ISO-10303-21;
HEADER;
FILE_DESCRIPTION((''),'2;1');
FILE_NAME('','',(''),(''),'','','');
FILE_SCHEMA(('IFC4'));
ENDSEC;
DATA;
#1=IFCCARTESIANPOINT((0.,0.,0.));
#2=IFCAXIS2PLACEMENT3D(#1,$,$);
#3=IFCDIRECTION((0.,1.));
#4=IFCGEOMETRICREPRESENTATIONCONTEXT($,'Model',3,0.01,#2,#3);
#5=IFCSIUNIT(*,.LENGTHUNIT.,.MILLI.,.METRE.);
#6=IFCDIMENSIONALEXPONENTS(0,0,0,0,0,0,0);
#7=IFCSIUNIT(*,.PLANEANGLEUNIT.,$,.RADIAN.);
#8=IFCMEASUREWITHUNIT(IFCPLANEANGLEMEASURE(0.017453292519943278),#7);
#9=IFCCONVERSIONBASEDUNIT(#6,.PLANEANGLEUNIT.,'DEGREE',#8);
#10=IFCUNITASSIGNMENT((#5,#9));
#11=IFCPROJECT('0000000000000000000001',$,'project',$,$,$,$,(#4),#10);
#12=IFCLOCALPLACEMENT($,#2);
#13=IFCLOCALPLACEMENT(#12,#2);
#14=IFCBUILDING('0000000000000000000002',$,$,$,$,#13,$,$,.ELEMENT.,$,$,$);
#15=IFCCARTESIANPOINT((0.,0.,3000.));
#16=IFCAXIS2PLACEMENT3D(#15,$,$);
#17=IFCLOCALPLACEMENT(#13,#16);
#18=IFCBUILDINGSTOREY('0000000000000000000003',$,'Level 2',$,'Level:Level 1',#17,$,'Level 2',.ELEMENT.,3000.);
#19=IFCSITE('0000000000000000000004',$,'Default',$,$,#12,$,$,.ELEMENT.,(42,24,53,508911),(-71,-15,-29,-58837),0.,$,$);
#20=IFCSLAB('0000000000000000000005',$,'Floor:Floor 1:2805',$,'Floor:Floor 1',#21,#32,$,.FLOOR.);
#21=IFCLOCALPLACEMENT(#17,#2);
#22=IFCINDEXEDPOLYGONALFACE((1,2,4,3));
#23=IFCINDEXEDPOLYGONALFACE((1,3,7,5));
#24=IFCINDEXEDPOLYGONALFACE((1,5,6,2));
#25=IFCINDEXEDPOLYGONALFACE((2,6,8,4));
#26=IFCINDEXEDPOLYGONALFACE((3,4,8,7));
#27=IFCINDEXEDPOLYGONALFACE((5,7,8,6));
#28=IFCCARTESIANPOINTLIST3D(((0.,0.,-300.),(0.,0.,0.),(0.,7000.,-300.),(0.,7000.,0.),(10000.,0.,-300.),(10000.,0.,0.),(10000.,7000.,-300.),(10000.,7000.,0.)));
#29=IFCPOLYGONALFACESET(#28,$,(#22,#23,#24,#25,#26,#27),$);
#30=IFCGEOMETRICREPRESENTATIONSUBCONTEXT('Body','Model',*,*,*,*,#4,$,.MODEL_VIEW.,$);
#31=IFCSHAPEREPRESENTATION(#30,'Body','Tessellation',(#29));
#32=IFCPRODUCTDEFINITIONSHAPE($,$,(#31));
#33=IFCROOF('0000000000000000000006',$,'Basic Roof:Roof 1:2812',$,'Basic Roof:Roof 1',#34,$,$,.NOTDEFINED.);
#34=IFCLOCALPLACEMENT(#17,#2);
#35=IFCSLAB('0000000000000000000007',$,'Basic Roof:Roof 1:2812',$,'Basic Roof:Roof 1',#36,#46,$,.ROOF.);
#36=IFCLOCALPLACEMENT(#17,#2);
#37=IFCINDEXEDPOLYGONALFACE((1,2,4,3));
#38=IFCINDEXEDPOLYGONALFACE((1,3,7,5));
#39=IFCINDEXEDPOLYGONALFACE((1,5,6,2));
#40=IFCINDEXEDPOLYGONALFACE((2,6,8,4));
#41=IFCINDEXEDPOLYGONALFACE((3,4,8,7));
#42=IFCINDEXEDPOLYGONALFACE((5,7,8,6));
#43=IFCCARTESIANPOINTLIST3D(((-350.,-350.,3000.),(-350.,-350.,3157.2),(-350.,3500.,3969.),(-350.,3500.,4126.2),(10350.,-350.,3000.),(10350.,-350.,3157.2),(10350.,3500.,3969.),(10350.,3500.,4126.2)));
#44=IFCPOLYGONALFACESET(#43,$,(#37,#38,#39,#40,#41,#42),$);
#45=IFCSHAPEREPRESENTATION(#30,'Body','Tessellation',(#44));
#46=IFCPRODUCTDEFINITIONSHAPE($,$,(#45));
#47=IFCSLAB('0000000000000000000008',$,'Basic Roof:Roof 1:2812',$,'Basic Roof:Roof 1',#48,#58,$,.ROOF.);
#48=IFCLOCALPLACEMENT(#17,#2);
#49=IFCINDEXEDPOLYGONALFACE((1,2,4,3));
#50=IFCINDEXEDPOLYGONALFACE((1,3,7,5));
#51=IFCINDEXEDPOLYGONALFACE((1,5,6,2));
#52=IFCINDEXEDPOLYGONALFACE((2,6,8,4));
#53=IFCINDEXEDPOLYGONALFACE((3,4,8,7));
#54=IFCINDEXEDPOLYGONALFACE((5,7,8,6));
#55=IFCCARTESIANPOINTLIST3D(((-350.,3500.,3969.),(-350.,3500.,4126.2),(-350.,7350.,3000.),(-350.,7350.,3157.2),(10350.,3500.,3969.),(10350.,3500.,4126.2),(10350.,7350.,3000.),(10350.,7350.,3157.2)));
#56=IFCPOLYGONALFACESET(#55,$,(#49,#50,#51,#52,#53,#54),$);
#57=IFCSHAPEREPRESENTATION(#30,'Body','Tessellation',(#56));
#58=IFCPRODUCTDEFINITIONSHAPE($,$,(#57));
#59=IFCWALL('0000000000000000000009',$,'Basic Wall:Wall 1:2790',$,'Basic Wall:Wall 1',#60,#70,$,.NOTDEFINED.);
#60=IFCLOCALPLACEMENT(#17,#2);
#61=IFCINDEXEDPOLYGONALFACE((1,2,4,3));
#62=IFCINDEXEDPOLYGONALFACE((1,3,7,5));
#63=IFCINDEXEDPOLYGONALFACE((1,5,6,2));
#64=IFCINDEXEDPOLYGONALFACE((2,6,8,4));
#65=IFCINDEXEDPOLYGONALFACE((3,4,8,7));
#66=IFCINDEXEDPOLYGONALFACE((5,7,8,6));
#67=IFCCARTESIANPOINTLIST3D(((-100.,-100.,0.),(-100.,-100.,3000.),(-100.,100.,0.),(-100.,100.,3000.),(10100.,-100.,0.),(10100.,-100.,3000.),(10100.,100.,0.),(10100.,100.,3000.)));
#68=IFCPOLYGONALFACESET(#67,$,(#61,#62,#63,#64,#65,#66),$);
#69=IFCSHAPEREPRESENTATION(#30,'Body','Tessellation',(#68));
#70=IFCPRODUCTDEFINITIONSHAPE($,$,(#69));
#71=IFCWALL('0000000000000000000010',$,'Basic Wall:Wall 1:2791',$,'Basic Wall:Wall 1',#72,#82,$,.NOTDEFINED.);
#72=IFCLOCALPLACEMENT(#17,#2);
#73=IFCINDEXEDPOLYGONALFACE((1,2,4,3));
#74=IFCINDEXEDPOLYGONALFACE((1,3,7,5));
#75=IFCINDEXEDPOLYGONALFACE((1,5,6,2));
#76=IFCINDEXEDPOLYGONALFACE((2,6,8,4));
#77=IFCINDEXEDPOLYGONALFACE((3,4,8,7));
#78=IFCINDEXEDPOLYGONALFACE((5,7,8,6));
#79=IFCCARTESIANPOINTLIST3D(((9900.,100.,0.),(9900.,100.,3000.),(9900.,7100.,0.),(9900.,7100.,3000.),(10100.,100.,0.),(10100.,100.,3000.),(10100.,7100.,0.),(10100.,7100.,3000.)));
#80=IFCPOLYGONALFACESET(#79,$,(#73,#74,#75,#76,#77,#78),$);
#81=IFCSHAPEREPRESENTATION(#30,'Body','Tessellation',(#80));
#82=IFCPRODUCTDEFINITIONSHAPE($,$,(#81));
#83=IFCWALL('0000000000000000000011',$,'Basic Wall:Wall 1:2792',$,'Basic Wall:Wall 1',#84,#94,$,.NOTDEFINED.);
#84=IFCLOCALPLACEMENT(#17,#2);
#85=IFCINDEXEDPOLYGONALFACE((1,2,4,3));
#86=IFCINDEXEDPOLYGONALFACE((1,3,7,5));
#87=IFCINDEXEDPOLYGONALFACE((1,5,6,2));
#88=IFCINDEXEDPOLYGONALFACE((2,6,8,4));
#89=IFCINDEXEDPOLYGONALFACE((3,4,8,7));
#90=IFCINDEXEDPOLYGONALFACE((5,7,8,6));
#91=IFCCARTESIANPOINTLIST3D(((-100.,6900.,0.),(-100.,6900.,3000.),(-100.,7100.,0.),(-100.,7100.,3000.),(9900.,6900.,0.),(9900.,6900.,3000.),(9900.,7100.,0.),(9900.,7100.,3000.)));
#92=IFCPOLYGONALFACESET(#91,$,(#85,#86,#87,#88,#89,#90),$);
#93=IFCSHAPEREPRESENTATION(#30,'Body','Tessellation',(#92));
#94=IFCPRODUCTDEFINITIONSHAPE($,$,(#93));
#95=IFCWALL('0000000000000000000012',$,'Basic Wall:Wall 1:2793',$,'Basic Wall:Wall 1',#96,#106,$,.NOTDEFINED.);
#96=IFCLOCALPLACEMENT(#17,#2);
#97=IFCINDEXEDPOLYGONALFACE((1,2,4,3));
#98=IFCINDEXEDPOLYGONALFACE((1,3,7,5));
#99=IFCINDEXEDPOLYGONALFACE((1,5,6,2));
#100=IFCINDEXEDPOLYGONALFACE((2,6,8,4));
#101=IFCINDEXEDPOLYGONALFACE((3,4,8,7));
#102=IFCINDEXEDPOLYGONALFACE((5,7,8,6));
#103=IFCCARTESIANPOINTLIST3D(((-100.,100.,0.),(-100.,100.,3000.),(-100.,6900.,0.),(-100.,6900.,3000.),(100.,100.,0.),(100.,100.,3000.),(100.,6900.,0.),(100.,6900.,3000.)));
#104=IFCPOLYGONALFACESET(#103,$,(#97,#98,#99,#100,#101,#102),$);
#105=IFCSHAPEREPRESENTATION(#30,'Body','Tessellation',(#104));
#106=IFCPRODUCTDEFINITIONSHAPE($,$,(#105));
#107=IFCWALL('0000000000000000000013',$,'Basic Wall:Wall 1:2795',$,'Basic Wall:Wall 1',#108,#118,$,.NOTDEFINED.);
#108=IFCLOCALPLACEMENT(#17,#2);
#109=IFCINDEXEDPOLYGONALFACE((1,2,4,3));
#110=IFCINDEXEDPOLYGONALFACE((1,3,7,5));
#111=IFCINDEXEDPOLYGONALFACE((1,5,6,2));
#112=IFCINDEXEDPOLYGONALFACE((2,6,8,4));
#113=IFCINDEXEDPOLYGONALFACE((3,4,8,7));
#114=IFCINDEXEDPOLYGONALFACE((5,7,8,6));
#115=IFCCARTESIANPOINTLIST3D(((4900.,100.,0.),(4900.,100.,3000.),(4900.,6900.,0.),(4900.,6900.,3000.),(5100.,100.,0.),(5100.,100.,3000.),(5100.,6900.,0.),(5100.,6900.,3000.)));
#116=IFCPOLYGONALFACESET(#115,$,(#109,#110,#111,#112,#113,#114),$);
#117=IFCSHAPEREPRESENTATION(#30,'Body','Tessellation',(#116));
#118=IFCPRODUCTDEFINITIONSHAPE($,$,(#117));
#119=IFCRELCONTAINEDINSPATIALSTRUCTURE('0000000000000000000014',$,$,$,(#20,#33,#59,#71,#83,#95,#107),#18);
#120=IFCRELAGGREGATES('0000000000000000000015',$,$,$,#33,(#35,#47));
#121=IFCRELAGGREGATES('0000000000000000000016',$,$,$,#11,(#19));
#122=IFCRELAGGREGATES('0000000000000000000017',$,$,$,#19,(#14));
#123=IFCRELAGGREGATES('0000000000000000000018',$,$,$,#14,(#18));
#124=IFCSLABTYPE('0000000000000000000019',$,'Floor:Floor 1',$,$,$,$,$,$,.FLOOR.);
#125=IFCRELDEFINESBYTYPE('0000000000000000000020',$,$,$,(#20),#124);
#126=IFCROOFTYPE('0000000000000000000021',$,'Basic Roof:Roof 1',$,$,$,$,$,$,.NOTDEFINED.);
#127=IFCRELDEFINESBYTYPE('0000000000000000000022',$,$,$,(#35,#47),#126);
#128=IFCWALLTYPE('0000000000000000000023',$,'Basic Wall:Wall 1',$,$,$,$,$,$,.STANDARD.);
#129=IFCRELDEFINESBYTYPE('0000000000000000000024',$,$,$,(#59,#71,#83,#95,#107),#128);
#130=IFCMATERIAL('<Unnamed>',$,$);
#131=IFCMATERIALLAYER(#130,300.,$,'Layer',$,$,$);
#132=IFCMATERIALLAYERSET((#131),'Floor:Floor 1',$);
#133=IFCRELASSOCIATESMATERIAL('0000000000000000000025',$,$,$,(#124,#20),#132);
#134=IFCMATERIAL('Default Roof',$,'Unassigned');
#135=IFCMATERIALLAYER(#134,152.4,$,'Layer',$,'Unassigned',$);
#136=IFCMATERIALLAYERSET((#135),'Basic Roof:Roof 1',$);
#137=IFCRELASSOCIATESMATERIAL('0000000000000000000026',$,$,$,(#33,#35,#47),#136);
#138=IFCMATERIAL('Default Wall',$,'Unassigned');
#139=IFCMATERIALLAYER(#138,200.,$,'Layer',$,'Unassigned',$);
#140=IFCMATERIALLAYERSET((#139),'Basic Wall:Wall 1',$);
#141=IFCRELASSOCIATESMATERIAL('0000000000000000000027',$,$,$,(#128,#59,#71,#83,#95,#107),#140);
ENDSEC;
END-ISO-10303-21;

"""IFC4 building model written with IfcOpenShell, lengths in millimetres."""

from ifc_helpers import new_model, entity, si_unit, converted_unit, direction, frame, frame_2d, origin, origin_2d_with_axis, place, context, subcontext, project, spatial, rectangle, extrude, material, layer, layer_set, layer_usage, type_object, element, aggregate, save


model = new_model("IFC4")

# Units and contexts
model_context = context("Model", 3, precision=0.01, world=origin(), true_north=direction((0.0, 1.0)))
body_context = subcontext(model_context, "Body", "Model", "MODEL_VIEW")
ifc_project = project(units=[si_unit("LENGTHUNIT", "METRE", prefix="MILLI"), converted_unit("PLANEANGLEUNIT", "DEGREE", entity("IfcPlaneAngleMeasure", 0.017453292519943278), si_unit("PLANEANGLEUNIT", "RADIAN"), dimensions=[0, 0, 0, 0, 0, 0, 0])], contexts=[model_context])

# Site, building, storey
site_placement = place(None, origin())
site = spatial("IfcSite", under=ifc_project, at=site_placement, Name="Default", CompositionType="ELEMENT", RefLatitude=(42, 24, 53, 508911), RefLongitude=(-71, -15, -29, -58837), RefElevation=0.0)
building_placement = place(site_placement, origin())
building = spatial("IfcBuilding", under=site, at=building_placement, CompositionType="ELEMENT")
storey_placement = place(building_placement, frame((0.0, 0.0, 3000.0)))
storey = spatial("IfcBuildingStorey", under=building, at=storey_placement, Name="Level 2", ObjectType="Level:Level 1", LongName="Level 2", CompositionType="ELEMENT", Elevation=3000.0)

# Slab
ifc_material_1 = material(Name="<Unnamed>")
ifc_layer_1 = layer(ifc_material_1, 300.0, Name="Layer")
ifc_layer_set_1 = layer_set([ifc_layer_1], Name="Floor:Floor 1")
ifc_layer_usage_1 = layer_usage(ifc_layer_set_1, "AXIS3", "POSITIVE", 0.0)
slab_type = type_object("IfcSlabType", Name="Floor:Floor 1", PredefinedType="FLOOR", material=ifc_layer_set_1)
slab_1_placement = place(storey_placement, origin())
element("IfcSlab", 1, at=slab_1_placement, inside=storey, type_object=slab_type, material=ifc_layer_usage_1, Name="Floor:Floor 1:2805", ObjectType="Floor:Floor 1", PredefinedType="FLOOR", context=body_context, shape_type="SweptSolid", body=[
    extrude(rectangle(XDim=7000.0, YDim=10000.0, at=origin_2d_with_axis()), frame((5000.0, 3500.0, 0.0), z_axis=(0.0, 0.0, -1.0), x_axis=(0.0, 1.0, 0.0)), (0.0, 0.0, 1.0), 300.0),
])

# Roof, slabs
ifc_material_2 = material(Name="Default Roof", Category="Unassigned")
ifc_layer_2 = layer(ifc_material_2, 152.4, Name="Layer", Category="Unassigned")
ifc_layer_set_2 = layer_set([ifc_layer_2], Name="Basic Roof:Roof 1")
roof_placement = place(storey_placement, frame((-350.0, -350.0, 3000.0)))
roof = element("IfcRoof", 2, at=roof_placement, inside=storey, material=ifc_layer_set_2, Name="Basic Roof:Roof 1:2812", ObjectType="Basic Roof:Roof 1", PredefinedType="NOTDEFINED")
roof_type = type_object("IfcRoofType", Name="Basic Roof:Roof 1", PredefinedType="NOTDEFINED")
slab_2_placement = place(roof_placement, origin())
slab_2 = element("IfcSlab", 3, at=slab_2_placement, type_object=roof_type, material=ifc_layer_set_2, Name="Basic Roof:Roof 1:2812", ObjectType="Basic Roof:Roof 1", PredefinedType="ROOF", context=body_context, shape_type="SweptSolid", body=[
    extrude(rectangle(XDim=10700.0, YDim=3970.1, at=frame_2d((0.0, 0.0), x_axis=(-1.0, 0.0))), frame((5350.0, 1925.0, 484.5), z_axis=(0.0, -0.244078, 0.969756), x_axis=(1.0, 0.0, 0.0)), (0.0, 0.244078, 0.969756), 157.2),
])
slab_3_placement = place(roof_placement, origin())
slab_3 = element("IfcSlab", 4, at=slab_3_placement, type_object=roof_type, material=ifc_layer_set_2, Name="Basic Roof:Roof 1:2812", ObjectType="Basic Roof:Roof 1", PredefinedType="ROOF", context=body_context, shape_type="SweptSolid", body=[
    extrude(rectangle(XDim=3970.1, YDim=10700.0, at=frame_2d((0.0, 0.0), x_axis=(0.0, -1.0))), frame((5350.0, 5775.0, 484.5), z_axis=(0.0, 0.244078, 0.969756), x_axis=(1.0, 0.0, 0.0)), (0.0, -0.244078, 0.969756), 157.2),
])
aggregate(roof, [slab_2, slab_3])

# Walls
ifc_material_3 = material(Name="Default Wall", Category="Unassigned")
ifc_layer_3 = layer(ifc_material_3, 200.0, Name="Layer", Category="Unassigned")
ifc_layer_set_3 = layer_set([ifc_layer_3], Name="Basic Wall:Wall 1")
ifc_layer_usage_2 = layer_usage(ifc_layer_set_3, "AXIS2", "NEGATIVE", 100.0)
wall_type = type_object("IfcWallType", Name="Basic Wall:Wall 1", PredefinedType="STANDARD", material=ifc_layer_set_3)
wall_1_placement = place(storey_placement, frame((-100.0, 0.0, 0.0)))
element("IfcWall", 5, at=wall_1_placement, inside=storey, type_object=wall_type, material=ifc_layer_usage_2, Name="Basic Wall:Wall 1:2790", ObjectType="Basic Wall:Wall 1", PredefinedType="NOTDEFINED", context=body_context, shape_type="SweptSolid", body=[
    extrude(rectangle(XDim=10200.0, YDim=200.0, at=frame_2d((5100.0, 0.0), x_axis=(-1.0, 0.0))), origin(), (0.0, 0.0, 1.0), 3000.0),
])
ifc_layer_usage_3 = layer_usage(ifc_layer_set_3, "AXIS2", "NEGATIVE", 100.0)
wall_2_placement = place(storey_placement, frame((10000.0, 100.0, 0.0), z_axis=(0.0, 0.0, 1.0), x_axis=(0.0, 1.0, 0.0)))
element("IfcWall", 6, at=wall_2_placement, inside=storey, type_object=wall_type, material=ifc_layer_usage_3, Name="Basic Wall:Wall 1:2791", ObjectType="Basic Wall:Wall 1", PredefinedType="NOTDEFINED", context=body_context, shape_type="SweptSolid", body=[
    extrude(rectangle(XDim=7000.0, YDim=200.0, at=frame_2d((3500.0, 0.0), x_axis=(-1.0, 0.0))), origin(), (0.0, 0.0, 1.0), 3000.0),
])
ifc_layer_usage_4 = layer_usage(ifc_layer_set_3, "AXIS2", "NEGATIVE", 100.0)
wall_3_placement = place(storey_placement, frame((9900.0, 7000.0, 0.0), z_axis=(0.0, 0.0, 1.0), x_axis=(-1.0, 0.0, 0.0)))
element("IfcWall", 7, at=wall_3_placement, inside=storey, type_object=wall_type, material=ifc_layer_usage_4, Name="Basic Wall:Wall 1:2792", ObjectType="Basic Wall:Wall 1", PredefinedType="NOTDEFINED", context=body_context, shape_type="SweptSolid", body=[
    extrude(rectangle(XDim=10000.0, YDim=200.0, at=frame_2d((5000.0, 0.0), x_axis=(-1.0, 0.0))), origin(), (0.0, 0.0, 1.0), 3000.0),
])
ifc_layer_usage_5 = layer_usage(ifc_layer_set_3, "AXIS2", "NEGATIVE", 100.0)
wall_4_placement = place(storey_placement, frame((0.0, 6900.0, 0.0), z_axis=(0.0, 0.0, 1.0), x_axis=(0.0, -1.0, 0.0)))
element("IfcWall", 8, at=wall_4_placement, inside=storey, type_object=wall_type, material=ifc_layer_usage_5, Name="Basic Wall:Wall 1:2793", ObjectType="Basic Wall:Wall 1", PredefinedType="NOTDEFINED", context=body_context, shape_type="SweptSolid", body=[
    extrude(rectangle(XDim=6800.0, YDim=200.0, at=frame_2d((3400.0, 0.0), x_axis=(-1.0, 0.0))), origin(), (0.0, 0.0, 1.0), 3000.0),
])
ifc_layer_usage_6 = layer_usage(ifc_layer_set_3, "AXIS2", "NEGATIVE", 100.0)
wall_5_placement = place(storey_placement, frame((5000.0, 100.0, 0.0), z_axis=(0.0, 0.0, 1.0), x_axis=(0.0, 1.0, 0.0)))
element("IfcWall", 9, at=wall_5_placement, inside=storey, type_object=wall_type, material=ifc_layer_usage_6, Name="Basic Wall:Wall 1:2795", ObjectType="Basic Wall:Wall 1", PredefinedType="NOTDEFINED", context=body_context, shape_type="SweptSolid", body=[
    extrude(rectangle(XDim=6800.0, YDim=200.0, at=frame_2d((3400.0, 0.0), x_axis=(-1.0, 0.0))), origin(), (0.0, 0.0, 1.0), 3000.0),
])

save(model, "model.ifc")
